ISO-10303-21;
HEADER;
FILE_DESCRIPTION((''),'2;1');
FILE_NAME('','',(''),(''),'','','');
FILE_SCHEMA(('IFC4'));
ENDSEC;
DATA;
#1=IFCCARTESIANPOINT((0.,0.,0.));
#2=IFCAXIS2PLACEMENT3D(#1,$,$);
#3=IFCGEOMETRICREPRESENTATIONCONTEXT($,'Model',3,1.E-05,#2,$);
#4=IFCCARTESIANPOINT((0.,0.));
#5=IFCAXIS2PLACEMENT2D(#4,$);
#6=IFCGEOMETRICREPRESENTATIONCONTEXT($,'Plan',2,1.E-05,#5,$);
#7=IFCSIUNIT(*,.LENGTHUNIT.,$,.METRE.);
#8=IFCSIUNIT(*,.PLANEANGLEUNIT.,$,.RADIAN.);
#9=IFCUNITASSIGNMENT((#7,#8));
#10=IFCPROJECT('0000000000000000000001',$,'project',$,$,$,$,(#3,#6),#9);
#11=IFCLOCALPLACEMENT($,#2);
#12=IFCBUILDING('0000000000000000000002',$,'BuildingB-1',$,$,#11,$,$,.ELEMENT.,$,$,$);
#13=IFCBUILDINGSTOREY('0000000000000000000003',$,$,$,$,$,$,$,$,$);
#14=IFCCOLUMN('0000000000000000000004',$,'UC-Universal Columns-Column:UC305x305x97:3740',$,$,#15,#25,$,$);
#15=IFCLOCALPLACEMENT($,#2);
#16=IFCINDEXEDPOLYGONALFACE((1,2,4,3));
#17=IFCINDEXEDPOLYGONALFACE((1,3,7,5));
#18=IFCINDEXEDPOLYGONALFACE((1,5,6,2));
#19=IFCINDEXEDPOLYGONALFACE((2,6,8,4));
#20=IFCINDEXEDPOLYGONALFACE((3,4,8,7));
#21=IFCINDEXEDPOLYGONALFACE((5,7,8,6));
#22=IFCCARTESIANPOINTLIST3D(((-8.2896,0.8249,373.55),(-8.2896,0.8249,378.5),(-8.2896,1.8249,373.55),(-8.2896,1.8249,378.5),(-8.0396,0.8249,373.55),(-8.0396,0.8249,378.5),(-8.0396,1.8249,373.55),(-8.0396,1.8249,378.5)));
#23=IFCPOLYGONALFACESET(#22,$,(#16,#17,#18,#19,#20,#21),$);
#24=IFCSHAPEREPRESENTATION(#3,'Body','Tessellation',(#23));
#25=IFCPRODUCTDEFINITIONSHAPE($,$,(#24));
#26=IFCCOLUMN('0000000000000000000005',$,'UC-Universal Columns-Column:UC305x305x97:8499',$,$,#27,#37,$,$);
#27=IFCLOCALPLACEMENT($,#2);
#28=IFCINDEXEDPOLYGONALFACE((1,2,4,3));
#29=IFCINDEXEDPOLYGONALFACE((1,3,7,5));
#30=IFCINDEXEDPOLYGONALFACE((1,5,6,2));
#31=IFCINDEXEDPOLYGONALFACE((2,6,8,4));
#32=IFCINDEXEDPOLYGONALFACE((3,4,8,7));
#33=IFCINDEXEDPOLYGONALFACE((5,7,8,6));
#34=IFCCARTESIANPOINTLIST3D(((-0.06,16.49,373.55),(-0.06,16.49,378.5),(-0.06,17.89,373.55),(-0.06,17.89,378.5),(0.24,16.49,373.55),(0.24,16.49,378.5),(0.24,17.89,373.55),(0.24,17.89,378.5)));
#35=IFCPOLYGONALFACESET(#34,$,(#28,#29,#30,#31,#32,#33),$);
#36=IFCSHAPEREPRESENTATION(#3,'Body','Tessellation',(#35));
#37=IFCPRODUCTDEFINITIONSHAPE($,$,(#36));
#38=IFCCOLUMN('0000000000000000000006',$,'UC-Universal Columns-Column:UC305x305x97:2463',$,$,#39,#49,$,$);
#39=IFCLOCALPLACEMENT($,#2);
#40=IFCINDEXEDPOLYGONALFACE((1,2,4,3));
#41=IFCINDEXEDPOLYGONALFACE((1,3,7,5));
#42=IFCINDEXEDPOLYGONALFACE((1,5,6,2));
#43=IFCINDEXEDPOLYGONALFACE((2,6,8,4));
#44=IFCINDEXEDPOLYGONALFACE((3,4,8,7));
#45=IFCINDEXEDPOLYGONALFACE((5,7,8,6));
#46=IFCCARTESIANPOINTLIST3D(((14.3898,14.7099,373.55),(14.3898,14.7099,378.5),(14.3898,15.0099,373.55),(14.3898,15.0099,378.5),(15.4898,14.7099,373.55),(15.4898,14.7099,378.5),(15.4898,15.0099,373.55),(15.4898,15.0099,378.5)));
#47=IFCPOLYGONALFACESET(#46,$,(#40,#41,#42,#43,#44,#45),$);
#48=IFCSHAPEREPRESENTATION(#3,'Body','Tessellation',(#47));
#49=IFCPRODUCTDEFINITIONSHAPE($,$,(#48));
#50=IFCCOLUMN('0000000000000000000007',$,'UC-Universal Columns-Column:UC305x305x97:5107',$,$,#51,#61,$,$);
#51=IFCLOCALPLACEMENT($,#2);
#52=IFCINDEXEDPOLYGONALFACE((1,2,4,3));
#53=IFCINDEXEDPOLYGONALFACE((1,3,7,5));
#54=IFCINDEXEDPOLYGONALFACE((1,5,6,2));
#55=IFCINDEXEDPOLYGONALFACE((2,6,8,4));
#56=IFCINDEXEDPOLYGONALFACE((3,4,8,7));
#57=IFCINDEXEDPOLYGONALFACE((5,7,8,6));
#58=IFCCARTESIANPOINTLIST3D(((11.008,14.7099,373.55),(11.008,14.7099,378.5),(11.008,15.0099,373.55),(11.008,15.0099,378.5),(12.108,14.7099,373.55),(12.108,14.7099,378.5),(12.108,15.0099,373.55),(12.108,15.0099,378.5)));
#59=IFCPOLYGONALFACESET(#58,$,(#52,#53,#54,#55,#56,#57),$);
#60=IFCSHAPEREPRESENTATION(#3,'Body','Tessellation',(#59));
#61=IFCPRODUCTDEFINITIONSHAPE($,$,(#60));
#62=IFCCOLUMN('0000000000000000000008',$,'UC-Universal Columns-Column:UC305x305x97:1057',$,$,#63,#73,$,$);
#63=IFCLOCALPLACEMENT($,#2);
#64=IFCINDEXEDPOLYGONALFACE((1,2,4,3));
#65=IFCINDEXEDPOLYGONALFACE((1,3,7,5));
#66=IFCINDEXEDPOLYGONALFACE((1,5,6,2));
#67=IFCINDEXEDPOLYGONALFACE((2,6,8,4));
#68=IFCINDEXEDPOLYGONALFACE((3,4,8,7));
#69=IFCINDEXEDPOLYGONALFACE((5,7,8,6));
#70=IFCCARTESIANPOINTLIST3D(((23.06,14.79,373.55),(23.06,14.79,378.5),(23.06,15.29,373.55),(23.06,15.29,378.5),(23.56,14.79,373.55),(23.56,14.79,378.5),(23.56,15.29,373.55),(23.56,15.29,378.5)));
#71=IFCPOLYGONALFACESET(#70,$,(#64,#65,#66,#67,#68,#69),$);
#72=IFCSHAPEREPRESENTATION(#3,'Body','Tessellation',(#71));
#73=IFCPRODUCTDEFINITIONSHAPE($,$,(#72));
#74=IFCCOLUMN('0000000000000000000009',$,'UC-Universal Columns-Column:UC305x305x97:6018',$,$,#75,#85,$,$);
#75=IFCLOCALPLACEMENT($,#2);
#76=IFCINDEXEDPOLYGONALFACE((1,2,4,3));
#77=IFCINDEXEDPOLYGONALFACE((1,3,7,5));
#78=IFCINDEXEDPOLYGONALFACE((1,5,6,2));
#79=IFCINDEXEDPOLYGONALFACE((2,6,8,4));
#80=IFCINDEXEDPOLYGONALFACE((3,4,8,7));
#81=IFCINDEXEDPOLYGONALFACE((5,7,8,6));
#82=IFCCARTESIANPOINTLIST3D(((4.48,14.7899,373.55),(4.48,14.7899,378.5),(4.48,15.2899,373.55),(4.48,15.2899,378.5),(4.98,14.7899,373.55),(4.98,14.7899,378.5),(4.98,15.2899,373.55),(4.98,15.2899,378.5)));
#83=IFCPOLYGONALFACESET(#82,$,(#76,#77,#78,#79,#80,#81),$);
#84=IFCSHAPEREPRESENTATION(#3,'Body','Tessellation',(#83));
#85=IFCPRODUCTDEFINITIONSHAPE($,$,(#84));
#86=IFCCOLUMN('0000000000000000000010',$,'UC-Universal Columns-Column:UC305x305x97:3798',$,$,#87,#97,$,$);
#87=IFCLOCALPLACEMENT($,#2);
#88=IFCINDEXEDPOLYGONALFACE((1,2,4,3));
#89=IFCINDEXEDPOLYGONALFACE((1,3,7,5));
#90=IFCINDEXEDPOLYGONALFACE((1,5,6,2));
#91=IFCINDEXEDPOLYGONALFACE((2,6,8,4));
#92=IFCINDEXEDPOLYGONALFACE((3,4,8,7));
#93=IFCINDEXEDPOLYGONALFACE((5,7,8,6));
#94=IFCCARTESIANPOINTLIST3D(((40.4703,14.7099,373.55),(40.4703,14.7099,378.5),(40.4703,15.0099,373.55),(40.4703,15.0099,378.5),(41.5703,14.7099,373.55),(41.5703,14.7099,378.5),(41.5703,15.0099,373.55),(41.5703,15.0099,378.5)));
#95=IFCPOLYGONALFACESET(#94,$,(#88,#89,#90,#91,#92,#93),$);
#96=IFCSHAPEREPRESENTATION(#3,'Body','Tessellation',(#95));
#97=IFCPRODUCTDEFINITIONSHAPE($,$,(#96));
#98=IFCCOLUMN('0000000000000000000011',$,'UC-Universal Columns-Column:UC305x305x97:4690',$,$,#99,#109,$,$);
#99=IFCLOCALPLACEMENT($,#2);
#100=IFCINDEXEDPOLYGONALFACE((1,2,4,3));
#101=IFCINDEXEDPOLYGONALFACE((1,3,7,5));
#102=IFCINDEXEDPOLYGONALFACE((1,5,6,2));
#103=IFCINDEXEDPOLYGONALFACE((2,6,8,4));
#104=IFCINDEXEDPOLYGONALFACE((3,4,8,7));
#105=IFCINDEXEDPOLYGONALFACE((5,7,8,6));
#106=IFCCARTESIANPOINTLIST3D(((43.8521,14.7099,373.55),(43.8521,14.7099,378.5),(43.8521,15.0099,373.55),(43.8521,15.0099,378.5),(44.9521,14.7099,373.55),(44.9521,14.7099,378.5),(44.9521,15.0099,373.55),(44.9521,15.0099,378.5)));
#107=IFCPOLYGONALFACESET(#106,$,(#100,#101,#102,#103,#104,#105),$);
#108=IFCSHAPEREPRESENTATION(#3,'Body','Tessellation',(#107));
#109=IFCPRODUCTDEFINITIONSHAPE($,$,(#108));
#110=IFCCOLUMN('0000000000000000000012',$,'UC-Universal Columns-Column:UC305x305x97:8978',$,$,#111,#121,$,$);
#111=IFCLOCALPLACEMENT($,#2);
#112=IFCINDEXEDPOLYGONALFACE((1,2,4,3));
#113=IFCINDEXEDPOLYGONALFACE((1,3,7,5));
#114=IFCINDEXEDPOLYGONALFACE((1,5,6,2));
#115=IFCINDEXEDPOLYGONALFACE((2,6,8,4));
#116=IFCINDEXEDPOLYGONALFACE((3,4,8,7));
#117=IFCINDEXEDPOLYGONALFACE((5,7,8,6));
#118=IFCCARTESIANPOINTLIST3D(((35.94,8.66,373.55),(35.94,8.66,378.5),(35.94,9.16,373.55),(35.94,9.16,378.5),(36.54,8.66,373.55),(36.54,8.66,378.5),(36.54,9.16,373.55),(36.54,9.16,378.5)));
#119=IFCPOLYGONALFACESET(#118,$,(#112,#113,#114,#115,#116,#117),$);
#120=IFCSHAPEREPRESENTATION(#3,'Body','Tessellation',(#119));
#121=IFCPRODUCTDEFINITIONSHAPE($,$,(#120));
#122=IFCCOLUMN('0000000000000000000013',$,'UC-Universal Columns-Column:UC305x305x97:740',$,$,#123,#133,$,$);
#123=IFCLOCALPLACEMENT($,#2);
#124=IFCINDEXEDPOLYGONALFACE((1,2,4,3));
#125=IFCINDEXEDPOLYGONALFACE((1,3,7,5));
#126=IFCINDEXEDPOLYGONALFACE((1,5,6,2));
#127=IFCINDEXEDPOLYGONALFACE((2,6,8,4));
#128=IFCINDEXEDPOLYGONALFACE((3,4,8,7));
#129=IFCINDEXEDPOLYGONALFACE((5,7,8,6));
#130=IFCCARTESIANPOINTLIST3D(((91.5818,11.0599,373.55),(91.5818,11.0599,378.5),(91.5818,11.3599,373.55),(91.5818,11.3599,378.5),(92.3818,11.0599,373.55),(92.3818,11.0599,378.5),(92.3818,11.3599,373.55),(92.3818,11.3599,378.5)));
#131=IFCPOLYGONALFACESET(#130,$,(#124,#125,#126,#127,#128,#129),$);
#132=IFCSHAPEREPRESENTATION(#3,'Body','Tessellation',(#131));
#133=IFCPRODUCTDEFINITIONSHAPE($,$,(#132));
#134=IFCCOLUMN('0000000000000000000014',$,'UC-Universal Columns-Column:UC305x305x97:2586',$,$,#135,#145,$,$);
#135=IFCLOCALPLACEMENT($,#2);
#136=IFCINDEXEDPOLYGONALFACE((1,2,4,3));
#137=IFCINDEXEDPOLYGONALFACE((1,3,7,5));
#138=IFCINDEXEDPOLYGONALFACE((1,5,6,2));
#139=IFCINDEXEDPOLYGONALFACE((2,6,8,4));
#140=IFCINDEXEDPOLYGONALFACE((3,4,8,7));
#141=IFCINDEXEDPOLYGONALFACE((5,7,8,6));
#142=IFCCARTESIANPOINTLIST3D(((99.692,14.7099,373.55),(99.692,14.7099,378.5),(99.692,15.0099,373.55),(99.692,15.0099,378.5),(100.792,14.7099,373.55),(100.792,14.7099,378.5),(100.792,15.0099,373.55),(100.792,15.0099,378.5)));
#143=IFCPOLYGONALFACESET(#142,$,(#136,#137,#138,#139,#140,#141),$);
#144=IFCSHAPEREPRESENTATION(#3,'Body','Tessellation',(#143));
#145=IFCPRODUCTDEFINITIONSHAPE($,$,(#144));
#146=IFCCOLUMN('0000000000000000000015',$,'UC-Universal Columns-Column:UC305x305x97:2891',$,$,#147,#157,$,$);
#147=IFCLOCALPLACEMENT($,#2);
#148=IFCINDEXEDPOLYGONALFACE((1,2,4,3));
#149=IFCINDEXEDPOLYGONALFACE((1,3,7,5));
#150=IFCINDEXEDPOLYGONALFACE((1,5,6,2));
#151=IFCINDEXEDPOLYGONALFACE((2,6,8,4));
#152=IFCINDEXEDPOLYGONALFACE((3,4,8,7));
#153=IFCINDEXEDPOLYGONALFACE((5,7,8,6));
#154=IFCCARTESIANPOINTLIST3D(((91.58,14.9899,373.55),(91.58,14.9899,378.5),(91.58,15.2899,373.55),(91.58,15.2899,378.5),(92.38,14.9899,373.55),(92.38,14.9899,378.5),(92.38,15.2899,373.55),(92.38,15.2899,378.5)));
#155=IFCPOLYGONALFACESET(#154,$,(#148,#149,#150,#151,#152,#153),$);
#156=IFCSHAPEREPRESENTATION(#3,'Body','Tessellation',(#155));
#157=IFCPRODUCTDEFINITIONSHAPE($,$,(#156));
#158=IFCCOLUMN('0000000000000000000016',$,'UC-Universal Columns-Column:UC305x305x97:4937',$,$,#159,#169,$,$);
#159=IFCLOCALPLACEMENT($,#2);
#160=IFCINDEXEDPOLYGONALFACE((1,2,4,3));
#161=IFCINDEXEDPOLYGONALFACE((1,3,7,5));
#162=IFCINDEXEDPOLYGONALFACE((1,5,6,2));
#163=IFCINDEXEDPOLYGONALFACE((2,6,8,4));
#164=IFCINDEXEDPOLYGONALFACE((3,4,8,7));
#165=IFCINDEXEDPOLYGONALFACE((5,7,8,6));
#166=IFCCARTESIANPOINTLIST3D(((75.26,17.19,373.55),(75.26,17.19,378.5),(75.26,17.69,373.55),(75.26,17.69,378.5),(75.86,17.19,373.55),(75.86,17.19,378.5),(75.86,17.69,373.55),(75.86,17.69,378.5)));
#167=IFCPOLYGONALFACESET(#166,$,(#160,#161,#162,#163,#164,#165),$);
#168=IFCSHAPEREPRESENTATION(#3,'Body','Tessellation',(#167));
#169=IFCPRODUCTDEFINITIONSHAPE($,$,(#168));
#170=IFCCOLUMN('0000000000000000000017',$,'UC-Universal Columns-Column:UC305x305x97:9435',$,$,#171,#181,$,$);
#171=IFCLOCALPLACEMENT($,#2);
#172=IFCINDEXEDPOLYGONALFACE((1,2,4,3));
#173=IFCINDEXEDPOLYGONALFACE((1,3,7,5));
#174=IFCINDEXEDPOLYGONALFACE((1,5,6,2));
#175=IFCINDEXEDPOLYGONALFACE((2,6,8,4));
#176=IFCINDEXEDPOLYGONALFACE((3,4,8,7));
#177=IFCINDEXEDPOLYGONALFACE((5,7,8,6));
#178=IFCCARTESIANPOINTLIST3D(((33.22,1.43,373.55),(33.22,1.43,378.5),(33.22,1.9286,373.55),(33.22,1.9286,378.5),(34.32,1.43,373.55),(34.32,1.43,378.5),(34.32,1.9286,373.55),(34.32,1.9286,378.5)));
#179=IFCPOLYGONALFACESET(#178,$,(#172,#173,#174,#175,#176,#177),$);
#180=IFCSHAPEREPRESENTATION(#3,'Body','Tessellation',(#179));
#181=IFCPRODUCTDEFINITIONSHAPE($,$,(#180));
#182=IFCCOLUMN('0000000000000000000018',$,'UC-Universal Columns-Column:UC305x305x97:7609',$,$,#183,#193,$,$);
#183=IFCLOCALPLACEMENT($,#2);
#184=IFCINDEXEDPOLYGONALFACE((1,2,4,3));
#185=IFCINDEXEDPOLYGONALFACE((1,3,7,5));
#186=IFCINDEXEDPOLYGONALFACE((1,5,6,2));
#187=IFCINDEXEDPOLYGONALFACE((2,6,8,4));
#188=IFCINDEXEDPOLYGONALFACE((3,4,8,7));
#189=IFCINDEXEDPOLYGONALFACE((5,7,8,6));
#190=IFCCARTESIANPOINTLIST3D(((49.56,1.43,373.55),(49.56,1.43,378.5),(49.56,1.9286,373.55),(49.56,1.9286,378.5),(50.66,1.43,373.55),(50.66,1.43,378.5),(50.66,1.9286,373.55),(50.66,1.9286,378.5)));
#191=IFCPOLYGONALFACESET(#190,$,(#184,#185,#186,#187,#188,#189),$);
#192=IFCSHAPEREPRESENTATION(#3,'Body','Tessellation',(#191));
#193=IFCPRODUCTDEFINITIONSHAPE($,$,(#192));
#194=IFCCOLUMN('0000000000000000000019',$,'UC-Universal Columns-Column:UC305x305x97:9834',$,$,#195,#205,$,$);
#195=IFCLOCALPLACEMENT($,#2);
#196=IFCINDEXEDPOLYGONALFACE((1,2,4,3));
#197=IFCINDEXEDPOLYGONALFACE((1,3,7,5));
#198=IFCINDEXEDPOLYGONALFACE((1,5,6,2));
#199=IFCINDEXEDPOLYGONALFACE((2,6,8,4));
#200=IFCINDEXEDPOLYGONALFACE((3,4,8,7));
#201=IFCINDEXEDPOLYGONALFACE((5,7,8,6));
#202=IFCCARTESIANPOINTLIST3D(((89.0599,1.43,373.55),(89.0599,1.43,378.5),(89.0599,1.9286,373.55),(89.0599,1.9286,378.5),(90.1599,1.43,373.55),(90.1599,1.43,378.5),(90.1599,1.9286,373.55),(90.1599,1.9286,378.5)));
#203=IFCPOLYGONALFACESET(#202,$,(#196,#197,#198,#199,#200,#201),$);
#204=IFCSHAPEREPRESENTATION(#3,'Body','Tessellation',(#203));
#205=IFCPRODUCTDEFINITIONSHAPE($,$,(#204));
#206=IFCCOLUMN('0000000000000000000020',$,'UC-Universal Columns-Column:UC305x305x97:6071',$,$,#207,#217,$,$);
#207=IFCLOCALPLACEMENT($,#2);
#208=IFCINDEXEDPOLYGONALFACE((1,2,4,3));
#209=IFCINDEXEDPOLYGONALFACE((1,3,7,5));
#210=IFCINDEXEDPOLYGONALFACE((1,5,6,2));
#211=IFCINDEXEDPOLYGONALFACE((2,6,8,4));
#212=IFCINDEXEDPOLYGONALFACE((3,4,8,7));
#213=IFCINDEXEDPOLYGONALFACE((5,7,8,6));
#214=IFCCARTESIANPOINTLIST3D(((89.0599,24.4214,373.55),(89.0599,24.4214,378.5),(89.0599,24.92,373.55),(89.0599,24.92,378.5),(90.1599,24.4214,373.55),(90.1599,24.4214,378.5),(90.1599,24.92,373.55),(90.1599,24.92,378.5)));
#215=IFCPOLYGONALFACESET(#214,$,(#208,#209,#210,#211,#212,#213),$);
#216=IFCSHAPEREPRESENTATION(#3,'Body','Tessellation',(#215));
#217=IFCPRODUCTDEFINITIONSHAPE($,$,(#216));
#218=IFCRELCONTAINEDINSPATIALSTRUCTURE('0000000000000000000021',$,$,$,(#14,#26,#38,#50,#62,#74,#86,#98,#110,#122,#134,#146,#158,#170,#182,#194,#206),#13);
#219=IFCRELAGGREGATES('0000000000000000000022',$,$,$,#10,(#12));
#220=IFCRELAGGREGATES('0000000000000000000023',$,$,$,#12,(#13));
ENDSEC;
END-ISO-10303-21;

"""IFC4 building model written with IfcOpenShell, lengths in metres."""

from ifc_helpers import new_model, si_unit, origin, origin_2d, place, context, project, spatial, polyline, outline, extrude, element, save


model = new_model("IFC4")

# Units and contexts
model_context = context("Model", 3, precision=1e-05, world=origin())
plan_context = context("Plan", 2, precision=1e-05, world=origin_2d())
ifc_project = project(units=[si_unit("LENGTHUNIT", "METRE"), si_unit("PLANEANGLEUNIT", "RADIAN")], contexts=[model_context, plan_context])

# Building, storey
building_placement = place(None, origin())
building = spatial("IfcBuilding", under=ifc_project, at=building_placement, Name="BuildingB-1", CompositionType="ELEMENT")
storey = spatial("IfcBuildingStorey", under=building)

# Columns
element("IfcColumn", 1, inside=storey, Name="UC-Universal Columns-Column:UC305x305x97:3740", context=model_context, shape_type="SweptSolid", body=[
    extrude(outline(polyline([(-8.0396, 1.8249, 378.5), (-8.2896, 1.8249, 378.5), (-8.2896, 0.8249, 378.5), (-8.0396, 0.8249, 378.5), (-8.0396, 1.8249, 378.5)])), None, (0.0, 0.0, -1.0), 4.95),
])
element("IfcColumn", 2, inside=storey, Name="UC-Universal Columns-Column:UC305x305x97:8499", context=model_context, shape_type="SweptSolid", body=[
    extrude(outline(polyline([(-0.06, 17.89, 378.5), (0.24, 17.89, 378.5), (0.24, 16.49, 378.5), (-0.06, 16.49, 378.5), (-0.06, 17.89, 378.5)])), None, (0.0, 0.0, -1.0), 4.95),
])
element("IfcColumn", 3, inside=storey, Name="UC-Universal Columns-Column:UC305x305x97:2463", context=model_context, shape_type="SweptSolid", body=[
    extrude(outline(polyline([(14.3898, 15.0099, 378.5), (15.4898, 15.0099, 378.5), (15.4898, 14.7099, 378.5), (14.3898, 14.7099, 378.5), (14.3898, 15.0099, 378.5)])), None, (0.0, 0.0, -1.0), 4.95),
])
element("IfcColumn", 4, inside=storey, Name="UC-Universal Columns-Column:UC305x305x97:5107", context=model_context, shape_type="SweptSolid", body=[
    extrude(outline(polyline([(11.008, 14.7099, 378.5), (11.008, 15.0099, 378.5), (12.108, 15.0099, 378.5), (12.108, 14.7099, 378.5), (11.008, 14.7099, 378.5)])), None, (0.0, 0.0, -1.0), 4.95),
])
element("IfcColumn", 5, inside=storey, Name="UC-Universal Columns-Column:UC305x305x97:1057", context=model_context, shape_type="SweptSolid", body=[
    extrude(outline(polyline([(23.06, 15.29, 378.5), (23.56, 15.29, 378.5), (23.56, 14.79, 378.5), (23.06, 14.79, 378.5), (23.06, 15.29, 378.5)])), None, (0.0, 0.0, -1.0), 4.95),
])
element("IfcColumn", 6, inside=storey, Name="UC-Universal Columns-Column:UC305x305x97:6018", context=model_context, shape_type="SweptSolid", body=[
    extrude(outline(polyline([(4.98, 15.2899, 378.5), (4.48, 15.2899, 378.5), (4.48, 14.7899, 378.5), (4.98, 14.7899, 378.5), (4.98, 15.2899, 378.5)])), None, (0.0, 0.0, -1.0), 4.95),
])
element("IfcColumn", 7, inside=storey, Name="UC-Universal Columns-Column:UC305x305x97:3798", context=model_context, shape_type="SweptSolid", body=[
    extrude(outline(polyline([(41.5703, 15.0099, 378.5), (40.4703, 15.0099, 378.5), (40.4703, 14.7099, 378.5), (41.5703, 14.7099, 378.5), (41.5703, 15.0099, 378.5)])), None, (0.0, 0.0, -1.0), 4.95),
])
element("IfcColumn", 8, inside=storey, Name="UC-Universal Columns-Column:UC305x305x97:4690", context=model_context, shape_type="SweptSolid", body=[
    extrude(outline(polyline([(44.9521, 14.7099, 378.5), (44.9521, 15.0099, 378.5), (43.8521, 15.0099, 378.5), (43.8521, 14.7099, 378.5), (44.9521, 14.7099, 378.5)])), None, (0.0, 0.0, -1.0), 4.95),
])
element("IfcColumn", 9, inside=storey, Name="UC-Universal Columns-Column:UC305x305x97:8978", context=model_context, shape_type="SweptSolid", body=[
    extrude(outline(polyline([(36.54, 8.66, 378.5), (35.94, 8.66, 378.5), (35.94, 9.16, 378.5), (36.54, 9.16, 378.5), (36.54, 8.66, 378.5)])), None, (0.0, 0.0, -1.0), 4.95),
])
element("IfcColumn", 10, inside=storey, Name="UC-Universal Columns-Column:UC305x305x97:740", context=model_context, shape_type="SweptSolid", body=[
    extrude(outline(polyline([(92.3818, 11.0599, 378.5), (91.5818, 11.0599, 378.5), (91.5818, 11.3599, 378.5), (92.3818, 11.3599, 378.5), (92.3818, 11.0599, 378.5)])), None, (0.0, 0.0, -1.0), 4.95),
])
element("IfcColumn", 11, inside=storey, Name="UC-Universal Columns-Column:UC305x305x97:2586", context=model_context, shape_type="SweptSolid", body=[
    extrude(outline(polyline([(100.792, 14.7099, 378.5), (100.792, 15.0099, 378.5), (99.692, 15.0099, 378.5), (99.692, 14.7099, 378.5), (100.792, 14.7099, 378.5)])), None, (0.0, 0.0, -1.0), 4.95),
])
element("IfcColumn", 12, inside=storey, Name="UC-Universal Columns-Column:UC305x305x97:2891", context=model_context, shape_type="SweptSolid", body=[
    extrude(outline(polyline([(92.38, 15.2899, 378.5), (91.58, 15.2899, 378.5), (91.58, 14.9899, 378.5), (92.38, 14.9899, 378.5), (92.38, 15.2899, 378.5)])), None, (0.0, 0.0, -1.0), 4.95),
])
element("IfcColumn", 13, inside=storey, Name="UC-Universal Columns-Column:UC305x305x97:4937", context=model_context, shape_type="SweptSolid", body=[
    extrude(outline(polyline([(75.26, 17.69, 378.5), (75.86, 17.69, 378.5), (75.86, 17.19, 378.5), (75.26, 17.19, 378.5), (75.26, 17.69, 378.5)])), None, (0.0, 0.0, -1.0), 4.95),
])
element("IfcColumn", 14, inside=storey, Name="UC-Universal Columns-Column:UC305x305x97:9435", context=model_context, shape_type="SweptSolid", body=[
    extrude(outline(polyline([(34.32, 1.43, 378.5), (33.22, 1.43, 378.5), (33.22, 1.9286, 378.5), (34.32, 1.9286, 378.5), (34.32, 1.43, 378.5)])), None, (0.0, 0.0, -1.0), 4.95),
])
element("IfcColumn", 15, inside=storey, Name="UC-Universal Columns-Column:UC305x305x97:7609", context=model_context, shape_type="SweptSolid", body=[
    extrude(outline(polyline([(50.66, 1.43, 378.5), (49.56, 1.43, 378.5), (49.56, 1.9286, 378.5), (50.66, 1.9286, 378.5), (50.66, 1.43, 378.5)])), None, (0.0, 0.0, -1.0), 4.95),
])
element("IfcColumn", 16, inside=storey, Name="UC-Universal Columns-Column:UC305x305x97:9834", context=model_context, shape_type="SweptSolid", body=[
    extrude(outline(polyline([(90.1599, 1.43, 378.5), (89.0599, 1.43, 378.5), (89.0599, 1.9286, 378.5), (90.1599, 1.9286, 378.5), (90.1599, 1.43, 378.5)])), None, (0.0, 0.0, -1.0), 4.95),
])
element("IfcColumn", 17, inside=storey, Name="UC-Universal Columns-Column:UC305x305x97:6071", context=model_context, shape_type="SweptSolid", body=[
    extrude(outline(polyline([(90.1599, 24.4214, 378.5), (89.0599, 24.4214, 378.5), (89.0599, 24.92, 378.5), (90.1599, 24.92, 378.5), (90.1599, 24.4214, 378.5)])), None, (0.0, 0.0, -1.0), 4.95),
])

save(model, "model.ifc")
